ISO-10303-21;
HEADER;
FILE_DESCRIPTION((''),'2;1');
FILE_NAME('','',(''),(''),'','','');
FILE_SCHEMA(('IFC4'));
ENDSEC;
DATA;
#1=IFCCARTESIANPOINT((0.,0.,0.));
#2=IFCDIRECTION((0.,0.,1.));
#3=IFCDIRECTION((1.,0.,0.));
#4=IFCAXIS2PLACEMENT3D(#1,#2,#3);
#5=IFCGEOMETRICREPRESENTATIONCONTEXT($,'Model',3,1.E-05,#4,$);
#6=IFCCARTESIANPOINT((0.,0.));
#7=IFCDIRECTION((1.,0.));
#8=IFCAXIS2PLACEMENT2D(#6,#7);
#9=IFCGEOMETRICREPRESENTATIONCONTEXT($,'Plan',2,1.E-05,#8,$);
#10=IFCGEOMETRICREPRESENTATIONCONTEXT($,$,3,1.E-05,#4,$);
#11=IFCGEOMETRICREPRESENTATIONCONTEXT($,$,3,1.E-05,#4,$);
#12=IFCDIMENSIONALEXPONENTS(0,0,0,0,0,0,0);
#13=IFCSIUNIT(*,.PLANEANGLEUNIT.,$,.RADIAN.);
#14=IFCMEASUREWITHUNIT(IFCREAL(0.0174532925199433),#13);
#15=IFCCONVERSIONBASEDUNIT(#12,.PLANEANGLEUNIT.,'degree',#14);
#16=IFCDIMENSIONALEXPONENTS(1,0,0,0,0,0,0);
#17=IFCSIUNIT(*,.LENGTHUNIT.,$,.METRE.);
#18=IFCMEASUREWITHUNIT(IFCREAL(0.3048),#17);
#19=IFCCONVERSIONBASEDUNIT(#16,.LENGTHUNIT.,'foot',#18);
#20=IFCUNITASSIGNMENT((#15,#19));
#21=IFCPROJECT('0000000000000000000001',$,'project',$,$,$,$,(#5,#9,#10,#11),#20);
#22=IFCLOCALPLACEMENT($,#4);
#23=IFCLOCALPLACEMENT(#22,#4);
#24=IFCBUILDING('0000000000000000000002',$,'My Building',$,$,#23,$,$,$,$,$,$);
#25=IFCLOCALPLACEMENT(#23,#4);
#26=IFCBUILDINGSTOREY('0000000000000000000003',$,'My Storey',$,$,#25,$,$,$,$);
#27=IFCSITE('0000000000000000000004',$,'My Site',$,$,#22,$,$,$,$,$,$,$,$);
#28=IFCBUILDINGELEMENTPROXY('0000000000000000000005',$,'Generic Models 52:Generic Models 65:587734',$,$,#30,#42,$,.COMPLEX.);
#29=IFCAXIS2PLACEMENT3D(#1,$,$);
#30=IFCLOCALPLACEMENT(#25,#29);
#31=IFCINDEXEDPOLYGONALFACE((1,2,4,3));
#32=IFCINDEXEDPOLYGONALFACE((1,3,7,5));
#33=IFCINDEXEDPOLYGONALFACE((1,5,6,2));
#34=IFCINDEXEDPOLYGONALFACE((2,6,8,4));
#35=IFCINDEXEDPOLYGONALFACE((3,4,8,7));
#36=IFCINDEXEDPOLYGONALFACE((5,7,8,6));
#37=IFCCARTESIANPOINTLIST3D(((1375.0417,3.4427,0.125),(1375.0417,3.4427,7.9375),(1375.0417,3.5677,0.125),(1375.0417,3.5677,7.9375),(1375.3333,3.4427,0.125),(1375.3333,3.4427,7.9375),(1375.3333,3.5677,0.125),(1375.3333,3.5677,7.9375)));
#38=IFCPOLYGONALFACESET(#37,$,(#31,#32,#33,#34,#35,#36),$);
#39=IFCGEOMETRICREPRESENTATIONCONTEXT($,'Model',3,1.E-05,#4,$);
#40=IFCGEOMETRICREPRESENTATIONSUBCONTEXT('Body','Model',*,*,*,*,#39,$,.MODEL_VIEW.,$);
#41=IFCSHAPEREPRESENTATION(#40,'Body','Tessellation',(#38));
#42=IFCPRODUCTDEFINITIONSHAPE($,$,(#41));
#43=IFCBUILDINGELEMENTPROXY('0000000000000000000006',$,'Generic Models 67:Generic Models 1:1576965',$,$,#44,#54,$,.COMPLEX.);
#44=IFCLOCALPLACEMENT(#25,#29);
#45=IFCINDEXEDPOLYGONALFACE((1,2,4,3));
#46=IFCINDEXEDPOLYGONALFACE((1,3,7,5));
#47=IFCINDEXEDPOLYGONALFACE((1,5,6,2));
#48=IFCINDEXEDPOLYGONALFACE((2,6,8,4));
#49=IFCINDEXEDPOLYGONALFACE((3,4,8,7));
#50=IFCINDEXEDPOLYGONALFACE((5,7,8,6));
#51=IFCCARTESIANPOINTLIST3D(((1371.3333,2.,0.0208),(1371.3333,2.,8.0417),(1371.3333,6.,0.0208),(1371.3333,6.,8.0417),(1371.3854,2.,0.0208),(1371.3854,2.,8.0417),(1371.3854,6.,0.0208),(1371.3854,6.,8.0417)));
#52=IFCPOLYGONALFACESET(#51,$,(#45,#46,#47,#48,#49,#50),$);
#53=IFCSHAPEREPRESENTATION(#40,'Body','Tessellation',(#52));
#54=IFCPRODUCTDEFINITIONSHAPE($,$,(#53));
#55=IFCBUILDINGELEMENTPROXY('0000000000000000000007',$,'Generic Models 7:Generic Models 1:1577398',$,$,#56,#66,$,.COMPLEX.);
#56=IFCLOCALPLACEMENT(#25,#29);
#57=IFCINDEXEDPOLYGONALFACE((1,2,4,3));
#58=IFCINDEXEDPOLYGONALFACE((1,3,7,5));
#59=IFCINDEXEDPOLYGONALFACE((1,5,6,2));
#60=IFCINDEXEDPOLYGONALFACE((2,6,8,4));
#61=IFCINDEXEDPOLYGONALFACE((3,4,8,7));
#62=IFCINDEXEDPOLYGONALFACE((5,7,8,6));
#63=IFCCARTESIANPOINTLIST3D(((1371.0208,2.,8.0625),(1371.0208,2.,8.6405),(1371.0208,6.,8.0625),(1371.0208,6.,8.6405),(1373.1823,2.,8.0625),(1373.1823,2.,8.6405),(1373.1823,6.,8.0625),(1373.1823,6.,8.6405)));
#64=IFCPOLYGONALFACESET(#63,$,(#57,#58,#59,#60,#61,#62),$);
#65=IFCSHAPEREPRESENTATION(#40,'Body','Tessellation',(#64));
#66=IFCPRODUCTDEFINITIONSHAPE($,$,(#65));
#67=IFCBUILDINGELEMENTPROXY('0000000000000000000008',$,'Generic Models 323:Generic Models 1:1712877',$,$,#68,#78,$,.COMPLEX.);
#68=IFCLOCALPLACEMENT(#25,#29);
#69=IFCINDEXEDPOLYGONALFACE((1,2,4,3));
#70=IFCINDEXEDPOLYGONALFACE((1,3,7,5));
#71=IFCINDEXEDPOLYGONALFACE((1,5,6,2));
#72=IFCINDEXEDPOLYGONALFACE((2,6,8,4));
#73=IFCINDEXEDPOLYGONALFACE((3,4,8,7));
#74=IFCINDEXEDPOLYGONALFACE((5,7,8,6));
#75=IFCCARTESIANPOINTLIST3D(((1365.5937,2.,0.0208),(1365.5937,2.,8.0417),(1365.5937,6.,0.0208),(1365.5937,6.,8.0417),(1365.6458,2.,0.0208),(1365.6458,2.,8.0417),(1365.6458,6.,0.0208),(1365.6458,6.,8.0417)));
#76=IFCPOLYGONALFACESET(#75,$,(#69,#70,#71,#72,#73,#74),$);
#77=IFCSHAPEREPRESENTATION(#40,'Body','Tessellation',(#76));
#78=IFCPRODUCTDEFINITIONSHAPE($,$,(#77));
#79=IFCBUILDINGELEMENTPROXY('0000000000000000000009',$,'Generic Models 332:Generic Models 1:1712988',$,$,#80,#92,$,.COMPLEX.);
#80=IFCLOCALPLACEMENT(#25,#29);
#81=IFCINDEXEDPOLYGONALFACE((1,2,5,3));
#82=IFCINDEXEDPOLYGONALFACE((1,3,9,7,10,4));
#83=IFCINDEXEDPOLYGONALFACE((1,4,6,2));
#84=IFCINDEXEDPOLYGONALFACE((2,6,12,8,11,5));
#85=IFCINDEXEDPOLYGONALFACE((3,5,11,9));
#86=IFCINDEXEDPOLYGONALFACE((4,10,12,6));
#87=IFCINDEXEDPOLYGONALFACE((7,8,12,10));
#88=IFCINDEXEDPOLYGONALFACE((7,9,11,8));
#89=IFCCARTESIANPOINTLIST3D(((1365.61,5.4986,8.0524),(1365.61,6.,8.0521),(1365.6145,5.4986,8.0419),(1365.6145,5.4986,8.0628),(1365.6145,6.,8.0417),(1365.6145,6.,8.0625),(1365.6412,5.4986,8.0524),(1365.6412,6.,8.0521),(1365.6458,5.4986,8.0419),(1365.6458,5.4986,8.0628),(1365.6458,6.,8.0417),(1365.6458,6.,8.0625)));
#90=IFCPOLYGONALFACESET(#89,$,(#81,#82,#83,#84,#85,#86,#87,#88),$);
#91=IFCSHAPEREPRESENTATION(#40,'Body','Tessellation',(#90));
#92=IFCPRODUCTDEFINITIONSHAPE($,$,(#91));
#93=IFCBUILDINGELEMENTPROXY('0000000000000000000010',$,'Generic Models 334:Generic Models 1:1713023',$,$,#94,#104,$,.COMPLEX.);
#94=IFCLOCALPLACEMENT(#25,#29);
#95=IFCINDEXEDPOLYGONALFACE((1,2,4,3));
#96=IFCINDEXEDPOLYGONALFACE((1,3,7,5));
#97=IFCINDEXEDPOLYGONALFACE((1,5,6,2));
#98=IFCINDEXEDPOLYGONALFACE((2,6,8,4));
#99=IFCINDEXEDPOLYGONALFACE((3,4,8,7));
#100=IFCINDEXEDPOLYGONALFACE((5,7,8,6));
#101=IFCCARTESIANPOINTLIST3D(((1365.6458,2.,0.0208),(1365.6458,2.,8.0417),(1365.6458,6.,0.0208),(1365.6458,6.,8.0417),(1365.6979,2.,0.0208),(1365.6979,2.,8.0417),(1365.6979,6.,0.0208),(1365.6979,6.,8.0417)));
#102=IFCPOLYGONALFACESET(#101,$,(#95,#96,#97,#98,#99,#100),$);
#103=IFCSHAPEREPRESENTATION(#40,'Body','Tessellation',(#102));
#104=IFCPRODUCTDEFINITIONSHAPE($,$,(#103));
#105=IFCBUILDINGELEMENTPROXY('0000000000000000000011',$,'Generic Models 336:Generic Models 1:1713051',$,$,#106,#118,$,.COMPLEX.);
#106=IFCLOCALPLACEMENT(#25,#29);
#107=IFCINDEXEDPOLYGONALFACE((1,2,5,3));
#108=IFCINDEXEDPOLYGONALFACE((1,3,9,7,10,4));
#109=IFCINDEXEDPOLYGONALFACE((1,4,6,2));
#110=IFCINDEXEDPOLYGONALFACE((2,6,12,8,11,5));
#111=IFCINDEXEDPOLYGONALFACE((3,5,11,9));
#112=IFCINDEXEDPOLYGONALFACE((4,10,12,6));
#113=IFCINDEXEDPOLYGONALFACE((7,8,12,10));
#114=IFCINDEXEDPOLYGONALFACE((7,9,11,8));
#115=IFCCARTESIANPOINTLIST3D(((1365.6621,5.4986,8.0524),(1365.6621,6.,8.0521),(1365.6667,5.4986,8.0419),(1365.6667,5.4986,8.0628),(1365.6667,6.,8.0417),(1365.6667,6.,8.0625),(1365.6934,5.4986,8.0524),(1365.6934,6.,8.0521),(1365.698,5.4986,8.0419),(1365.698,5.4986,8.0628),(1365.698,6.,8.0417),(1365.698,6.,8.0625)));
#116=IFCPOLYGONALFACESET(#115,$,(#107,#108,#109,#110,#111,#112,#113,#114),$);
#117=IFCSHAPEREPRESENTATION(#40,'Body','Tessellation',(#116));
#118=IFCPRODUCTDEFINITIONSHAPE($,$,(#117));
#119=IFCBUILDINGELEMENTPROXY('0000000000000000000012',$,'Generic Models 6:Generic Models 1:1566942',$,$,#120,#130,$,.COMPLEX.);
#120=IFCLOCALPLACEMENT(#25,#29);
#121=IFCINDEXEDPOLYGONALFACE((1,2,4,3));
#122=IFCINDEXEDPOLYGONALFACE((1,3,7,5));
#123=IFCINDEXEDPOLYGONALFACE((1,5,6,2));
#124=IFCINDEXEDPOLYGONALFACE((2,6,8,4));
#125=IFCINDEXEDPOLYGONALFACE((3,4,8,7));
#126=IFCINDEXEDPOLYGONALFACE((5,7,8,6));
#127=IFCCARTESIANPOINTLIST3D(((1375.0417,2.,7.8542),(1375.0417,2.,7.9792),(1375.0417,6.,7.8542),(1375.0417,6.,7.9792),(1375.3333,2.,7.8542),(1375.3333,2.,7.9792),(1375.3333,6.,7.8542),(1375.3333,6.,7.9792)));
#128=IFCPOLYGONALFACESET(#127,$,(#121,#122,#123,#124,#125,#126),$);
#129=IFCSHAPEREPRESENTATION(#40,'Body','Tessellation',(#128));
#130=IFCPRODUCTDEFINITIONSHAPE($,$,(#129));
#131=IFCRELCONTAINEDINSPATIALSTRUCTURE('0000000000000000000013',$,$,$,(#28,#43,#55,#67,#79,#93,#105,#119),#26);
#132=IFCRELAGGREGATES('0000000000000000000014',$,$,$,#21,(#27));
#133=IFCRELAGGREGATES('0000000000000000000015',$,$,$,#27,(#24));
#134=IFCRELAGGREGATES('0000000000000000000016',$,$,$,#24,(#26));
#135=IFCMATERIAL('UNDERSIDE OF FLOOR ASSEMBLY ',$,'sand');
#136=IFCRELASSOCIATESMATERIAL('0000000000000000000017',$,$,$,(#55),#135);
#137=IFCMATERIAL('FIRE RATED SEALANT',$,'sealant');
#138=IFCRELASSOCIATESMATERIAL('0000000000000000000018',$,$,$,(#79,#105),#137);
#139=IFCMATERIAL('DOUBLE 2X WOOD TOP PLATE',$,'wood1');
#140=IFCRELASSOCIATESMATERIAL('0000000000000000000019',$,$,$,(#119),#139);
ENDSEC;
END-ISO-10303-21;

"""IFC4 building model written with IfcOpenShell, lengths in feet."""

from ifc_helpers import new_model, entity, si_unit, converted_unit, frame, origin_with_axes, origin_2d_with_axis, place, context, subcontext, project, spatial, polyline, line, indexed_curve, outline, extrude, material, element, save


model = new_model("IFC4")

# Units and contexts
model_context_1 = context("Model", 3, precision=1e-05, world=origin_with_axes())
plan_context = context("Plan", 2, precision=1e-05, world=origin_2d_with_axis())
model_context_2 = context("Model", 3, precision=1e-05, world=origin_with_axes())
context_of_model_1 = context(None, 3, precision=1e-05, world=origin_with_axes())
context_of_model_2 = context(None, 3, precision=1e-05, world=origin_with_axes())
body_context = subcontext(model_context_2, "Body", "Model", "MODEL_VIEW")
ifc_project = project(units=[converted_unit("PLANEANGLEUNIT", "degree", entity("IfcReal", 0.0174532925199433), si_unit("PLANEANGLEUNIT", "RADIAN"), dimensions=[0, 0, 0, 0, 0, 0, 0]), converted_unit("LENGTHUNIT", "foot", entity("IfcReal", 0.3048), si_unit("LENGTHUNIT", "METRE"), dimensions=[1, 0, 0, 0, 0, 0, 0])], contexts=[model_context_1, plan_context, context_of_model_1, context_of_model_2])

# Site, building, storey
site_placement = place(None, origin_with_axes())
site = spatial("IfcSite", under=ifc_project, at=site_placement, Name="My Site")
building_placement = place(site_placement, origin_with_axes())
building = spatial("IfcBuilding", under=site, at=building_placement, Name="My Building")
storey_placement = place(building_placement, origin_with_axes())
storey = spatial("IfcBuildingStorey", under=building, at=storey_placement, Name="My Storey")

# Building element proxies
ifc_material_1 = material(Name="UNDERSIDE OF FLOOR ASSEMBLY ", Category="sand")
ifc_material_2 = material(Name="DOUBLE 2X WOOD TOP PLATE", Category="wood1")
proxy_1_placement = place(storey_placement, frame((1375.0417, 3.4427, 0.125), z_axis=(1.0, 0.0, 0.0), x_axis=(0.0, 0.0, -1.0)))
element("IfcBuildingElementProxy", 1, at=proxy_1_placement, inside=storey, Name="Generic Models 52:Generic Models 65:587734", PredefinedType="COMPLEX", context=body_context, shape_type="SweptSolid", body=[
    extrude(outline(polyline([(-3.9062, -0.0625), (3.9062, -0.0625), (3.9062, 0.0625), (-3.9062, 0.0625), (-3.9062, -0.0625)])), frame((-3.9062, 0.0625, 0.0), z_axis=(0.0, 0.0, -1.0), x_axis=(-1.0, 0.0, 0.0)), (0.0, 0.0, -1.0), 0.2917),
])
proxy_2_placement = place(storey_placement, frame((1371.3333, 6.0, 0.0208), z_axis=(0.0, -1.0, 0.0), x_axis=(0.0, 0.0, -1.0)))
element("IfcBuildingElementProxy", 2, at=proxy_2_placement, inside=storey, Name="Generic Models 67:Generic Models 1:1576965", PredefinedType="COMPLEX", context=body_context, shape_type="SweptSolid", body=[
    extrude(outline(polyline([(-0.026, -4.0104), (0.026, -4.0104), (0.026, 4.0104), (-0.026, 4.0104), (-0.026, -4.0104)])), frame((-4.0104, 0.026, 0.0), z_axis=(0.0, 0.0, -1.0), x_axis=(0.0, 1.0, 0.0)), (0.0, 0.0, -1.0), 4.0),
])
proxy_3_placement = place(storey_placement, frame((1371.0208, 6.0, 8.0625), z_axis=(0.0, -1.0, 0.0), x_axis=(0.0, 0.0, -1.0)))
element("IfcBuildingElementProxy", 3, at=proxy_3_placement, inside=storey, material=ifc_material_1, Name="Generic Models 7:Generic Models 1:1577398", PredefinedType="COMPLEX", context=body_context, shape_type="SweptSolid", body=[
    extrude(outline(polyline([(-0.289, -1.0807), (0.289, -1.0807), (0.289, 1.0807), (-0.289, 1.0807), (-0.289, -1.0807)])), frame((-0.289, 1.0807, 0.0), z_axis=(0.0, 0.0, -1.0), x_axis=(-1.0, 0.0, 0.0)), (0.0, 0.0, -1.0), 4.0),
])
proxy_4_placement = place(storey_placement, frame((1365.5937, 6.0, 0.0208), z_axis=(0.0, -1.0, 0.0), x_axis=(0.0, 0.0, 1.0)))
element("IfcBuildingElementProxy", 4, at=proxy_4_placement, inside=storey, Name="Generic Models 323:Generic Models 1:1712877", PredefinedType="COMPLEX", context=body_context, shape_type="SweptSolid", body=[
    extrude(outline(polyline([(-4.0104, -0.026), (4.0104, -0.026), (4.0104, 0.026), (-4.0104, 0.026), (-4.0104, -0.026)])), frame((4.0104, -0.026, 0.0), z_axis=(0.0, 0.0, -1.0), x_axis=(1.0, 0.0, 0.0)), (0.0, 0.0, -1.0), 4.0),
])
ifc_material_3 = material(Name="FIRE RATED SEALANT", Category="sealant")
proxy_5_placement = place(storey_placement, frame((1365.6101, 6.0, 8.0417), z_axis=(0.0, -1.0, 0.0), x_axis=(0.0, 0.0, 1.0)))
element("IfcBuildingElementProxy", 5, at=proxy_5_placement, inside=storey, material=ifc_material_3, Name="Generic Models 332:Generic Models 1:1712988", PredefinedType="COMPLEX", context=body_context, shape_type="SweptSolid", body=[
    extrude(outline(polyline([(0.0201, 0.0), (0.0107, 0.0065), (0.0093, 0.0178), (-0.0175, 0.0016), (-0.016, -0.0097), (-0.0066, -0.0162), (0.0201, 0.0)])), frame((0.0104, -0.0186, 0.0), z_axis=(0.0, 0.0, -1.0), x_axis=(0.51911, -0.854707, 0.0)), (0.000294, -0.000474, -1.0), 0.5014),
])
proxy_6_placement = place(storey_placement, frame((1365.6458, 6.0, 0.0208), z_axis=(0.0, -1.0, 0.0), x_axis=(0.0, 0.0, 1.0)))
element("IfcBuildingElementProxy", 6, at=proxy_6_placement, inside=storey, Name="Generic Models 334:Generic Models 1:1713023", PredefinedType="COMPLEX", context=body_context, shape_type="SweptSolid", body=[
    extrude(outline(polyline([(-4.0104, -0.026), (4.0104, -0.026), (4.0104, 0.026), (-4.0104, 0.026), (-4.0104, -0.026)])), frame((4.0104, -0.026, 0.0), z_axis=(0.0, 0.0, -1.0), x_axis=(1.0, 0.0, 0.0)), (0.0, 0.0, -1.0), 4.0),
])
proxy_7_placement = place(storey_placement, frame((1365.6622, 6.0, 8.0417), z_axis=(0.0, -1.0, 0.0), x_axis=(0.0, 0.0, 1.0)))
element("IfcBuildingElementProxy", 7, at=proxy_7_placement, inside=storey, material=ifc_material_3, Name="Generic Models 336:Generic Models 1:1713051", PredefinedType="COMPLEX", context=body_context, shape_type="SweptSolid", body=[
    extrude(outline(polyline([(0.0201, 0.0), (0.0107, 0.0065), (0.0093, 0.0178), (-0.0175, 0.0016), (-0.016, -0.0097), (-0.0066, -0.0162), (0.0201, 0.0)])), frame((0.0104, -0.0186, 0.0), z_axis=(0.0, 0.0, -1.0), x_axis=(0.51911, -0.854707, 0.0)), (0.000294, -0.000474, -1.0), 0.5014),
])
proxy_8_placement = place(storey_placement, frame((1375.0417, 6.0, 7.8542), z_axis=(0.0, -1.0, 0.0), x_axis=(0.0, 0.0, -1.0)))
element("IfcBuildingElementProxy", 8, at=proxy_8_placement, inside=storey, material=ifc_material_2, Name="Generic Models 6:Generic Models 1:1566942", PredefinedType="COMPLEX", context=body_context, shape_type="SweptSolid", body=[
    extrude(outline(indexed_curve([(-0.0625, -0.1458), (0.0625, -0.1458), (0.0625, 0.1458), (-0.0625, 0.1458)], segments=[line(3, 2), line(2, 1), line(1, 4), line(4, 3)], self_intersect=False)), frame((-0.0625, 0.1458, 0.0), z_axis=(0.0, 0.0, -1.0), x_axis=(-1.0, 0.0, 0.0)), (0.0, 0.0, -1.0), 4.0),
])

save(model, "model.ifc")
